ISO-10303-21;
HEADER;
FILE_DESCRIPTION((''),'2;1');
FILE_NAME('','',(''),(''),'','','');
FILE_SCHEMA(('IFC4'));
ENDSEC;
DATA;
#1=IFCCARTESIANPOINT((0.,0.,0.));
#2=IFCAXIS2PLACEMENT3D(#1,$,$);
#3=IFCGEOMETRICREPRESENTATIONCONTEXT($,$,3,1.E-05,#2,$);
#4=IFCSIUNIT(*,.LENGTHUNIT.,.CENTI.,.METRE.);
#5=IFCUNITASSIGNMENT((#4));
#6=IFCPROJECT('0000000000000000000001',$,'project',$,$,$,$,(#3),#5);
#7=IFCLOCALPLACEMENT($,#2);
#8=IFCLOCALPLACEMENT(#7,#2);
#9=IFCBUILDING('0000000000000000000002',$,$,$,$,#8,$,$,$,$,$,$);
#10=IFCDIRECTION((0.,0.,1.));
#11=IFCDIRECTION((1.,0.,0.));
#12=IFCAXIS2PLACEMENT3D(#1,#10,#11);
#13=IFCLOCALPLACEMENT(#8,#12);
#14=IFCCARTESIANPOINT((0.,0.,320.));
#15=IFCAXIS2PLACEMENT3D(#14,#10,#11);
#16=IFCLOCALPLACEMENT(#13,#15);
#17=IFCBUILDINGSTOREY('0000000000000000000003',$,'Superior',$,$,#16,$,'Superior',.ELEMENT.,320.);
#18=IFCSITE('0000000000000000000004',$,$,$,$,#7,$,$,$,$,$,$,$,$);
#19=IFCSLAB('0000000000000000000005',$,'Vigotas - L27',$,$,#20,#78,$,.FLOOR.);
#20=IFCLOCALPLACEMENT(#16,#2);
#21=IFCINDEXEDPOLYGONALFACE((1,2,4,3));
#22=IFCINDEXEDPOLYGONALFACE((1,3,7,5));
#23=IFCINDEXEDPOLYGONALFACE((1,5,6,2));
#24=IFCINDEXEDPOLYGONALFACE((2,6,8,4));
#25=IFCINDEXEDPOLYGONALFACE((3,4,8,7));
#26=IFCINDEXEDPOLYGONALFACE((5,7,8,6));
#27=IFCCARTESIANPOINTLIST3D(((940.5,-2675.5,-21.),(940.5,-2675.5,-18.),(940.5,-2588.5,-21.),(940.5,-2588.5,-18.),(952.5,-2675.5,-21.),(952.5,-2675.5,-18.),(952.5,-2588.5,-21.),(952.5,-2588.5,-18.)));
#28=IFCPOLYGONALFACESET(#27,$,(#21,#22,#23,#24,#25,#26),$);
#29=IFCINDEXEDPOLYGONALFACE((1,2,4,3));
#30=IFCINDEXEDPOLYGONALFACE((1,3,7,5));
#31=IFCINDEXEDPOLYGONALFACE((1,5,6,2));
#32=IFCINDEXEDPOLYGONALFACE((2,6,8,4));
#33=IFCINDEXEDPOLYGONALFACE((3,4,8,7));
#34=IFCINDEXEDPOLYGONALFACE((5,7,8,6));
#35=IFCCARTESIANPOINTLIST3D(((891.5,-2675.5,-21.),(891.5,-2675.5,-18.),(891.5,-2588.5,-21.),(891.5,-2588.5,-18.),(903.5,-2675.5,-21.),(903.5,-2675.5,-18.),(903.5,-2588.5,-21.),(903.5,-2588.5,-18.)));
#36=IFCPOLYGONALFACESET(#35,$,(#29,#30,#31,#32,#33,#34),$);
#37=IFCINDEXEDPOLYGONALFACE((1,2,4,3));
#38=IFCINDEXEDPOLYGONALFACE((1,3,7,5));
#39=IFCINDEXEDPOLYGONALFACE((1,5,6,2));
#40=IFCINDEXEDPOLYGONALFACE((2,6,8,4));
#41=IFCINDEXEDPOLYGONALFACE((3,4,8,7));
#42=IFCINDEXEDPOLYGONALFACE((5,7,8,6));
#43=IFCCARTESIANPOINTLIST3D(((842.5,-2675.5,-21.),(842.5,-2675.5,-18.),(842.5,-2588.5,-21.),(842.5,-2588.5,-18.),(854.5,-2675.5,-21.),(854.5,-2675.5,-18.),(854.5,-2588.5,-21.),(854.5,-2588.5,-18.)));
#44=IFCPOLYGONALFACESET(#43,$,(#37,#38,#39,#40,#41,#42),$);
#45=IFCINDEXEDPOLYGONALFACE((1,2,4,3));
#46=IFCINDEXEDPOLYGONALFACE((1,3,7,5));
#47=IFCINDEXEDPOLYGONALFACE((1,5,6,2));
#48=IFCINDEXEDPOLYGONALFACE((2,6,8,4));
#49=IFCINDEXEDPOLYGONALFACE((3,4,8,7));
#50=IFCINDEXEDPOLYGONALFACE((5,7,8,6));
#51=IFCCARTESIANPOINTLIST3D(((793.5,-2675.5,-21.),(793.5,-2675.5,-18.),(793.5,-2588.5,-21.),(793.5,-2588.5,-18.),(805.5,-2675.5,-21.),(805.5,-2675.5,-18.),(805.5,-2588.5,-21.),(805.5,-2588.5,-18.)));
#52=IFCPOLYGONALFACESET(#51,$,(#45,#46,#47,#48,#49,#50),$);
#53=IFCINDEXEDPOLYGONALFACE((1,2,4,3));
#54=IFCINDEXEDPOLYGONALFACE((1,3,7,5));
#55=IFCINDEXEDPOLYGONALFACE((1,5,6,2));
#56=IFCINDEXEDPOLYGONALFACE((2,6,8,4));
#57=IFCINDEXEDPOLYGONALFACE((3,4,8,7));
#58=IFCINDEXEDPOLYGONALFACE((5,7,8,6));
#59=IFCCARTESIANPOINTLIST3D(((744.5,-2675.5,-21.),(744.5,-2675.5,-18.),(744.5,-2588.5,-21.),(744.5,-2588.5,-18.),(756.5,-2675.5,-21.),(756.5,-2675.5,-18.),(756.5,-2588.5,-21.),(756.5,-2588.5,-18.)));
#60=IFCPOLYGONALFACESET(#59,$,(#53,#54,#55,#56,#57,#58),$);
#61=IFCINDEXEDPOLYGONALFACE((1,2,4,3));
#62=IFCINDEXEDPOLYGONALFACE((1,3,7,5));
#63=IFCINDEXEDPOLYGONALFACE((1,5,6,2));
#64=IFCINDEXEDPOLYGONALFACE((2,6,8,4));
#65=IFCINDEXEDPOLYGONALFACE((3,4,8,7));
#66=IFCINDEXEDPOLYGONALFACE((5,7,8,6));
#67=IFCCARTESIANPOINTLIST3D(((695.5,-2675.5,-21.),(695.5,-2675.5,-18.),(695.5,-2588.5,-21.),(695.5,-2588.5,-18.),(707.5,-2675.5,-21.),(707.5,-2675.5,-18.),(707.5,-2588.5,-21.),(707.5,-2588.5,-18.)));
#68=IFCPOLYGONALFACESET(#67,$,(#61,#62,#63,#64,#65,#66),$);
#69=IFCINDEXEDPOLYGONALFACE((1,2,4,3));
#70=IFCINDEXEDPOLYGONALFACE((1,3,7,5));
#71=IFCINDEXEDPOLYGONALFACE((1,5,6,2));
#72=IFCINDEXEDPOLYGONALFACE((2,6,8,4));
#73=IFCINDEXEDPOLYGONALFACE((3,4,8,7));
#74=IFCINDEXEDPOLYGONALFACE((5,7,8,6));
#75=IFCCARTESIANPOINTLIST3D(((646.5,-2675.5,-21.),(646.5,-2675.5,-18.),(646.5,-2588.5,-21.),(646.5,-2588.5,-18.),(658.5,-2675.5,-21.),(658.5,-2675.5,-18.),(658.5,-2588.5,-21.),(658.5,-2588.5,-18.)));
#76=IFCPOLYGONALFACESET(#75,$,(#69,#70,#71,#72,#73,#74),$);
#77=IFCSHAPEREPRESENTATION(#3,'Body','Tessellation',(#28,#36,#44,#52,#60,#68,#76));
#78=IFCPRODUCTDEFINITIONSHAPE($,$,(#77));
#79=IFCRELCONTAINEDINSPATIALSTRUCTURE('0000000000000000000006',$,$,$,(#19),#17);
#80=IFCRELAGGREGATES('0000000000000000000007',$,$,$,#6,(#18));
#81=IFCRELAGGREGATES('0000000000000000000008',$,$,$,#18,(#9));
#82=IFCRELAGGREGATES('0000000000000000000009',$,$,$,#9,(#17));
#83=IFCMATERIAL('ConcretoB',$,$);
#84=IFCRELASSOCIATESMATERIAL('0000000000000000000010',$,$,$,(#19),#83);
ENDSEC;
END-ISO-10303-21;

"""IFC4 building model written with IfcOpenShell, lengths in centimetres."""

from ifc_helpers import new_model, si_unit, frame, origin, origin_with_axes, place, context, project, spatial, polyline, outline, extrude, material, element, save


model = new_model("IFC4")

# Units and contexts
context_of_model = context(None, 3, precision=1e-05, world=origin())
ifc_project = project(units=[si_unit("LENGTHUNIT", "METRE", prefix="CENTI")], contexts=[context_of_model])

# Site, building, storey
site_placement = place(None, origin())
site = spatial("IfcSite", under=ifc_project, at=site_placement)
building_placement = place(site_placement, origin())
building = spatial("IfcBuilding", under=site, at=building_placement)
placement = place(building_placement, origin_with_axes())
storey_placement = place(placement, frame((0.0, 0.0, 320.0), z_axis=(0.0, 0.0, 1.0), x_axis=(1.0, 0.0, 0.0)))
storey = spatial("IfcBuildingStorey", under=building, at=storey_placement, Name="Superior", LongName="Superior", CompositionType="ELEMENT", Elevation=320.0)

# Shared definitions
ifc_material = material(Name="ConcretoB")

# Slab
slab_1_placement = place(storey_placement, frame((799.5, -2632.0, -18.0), z_axis=(0.0, 0.0, 1.0), x_axis=(1.0, 0.0, 0.0)))
element("IfcSlab", 1, at=slab_1_placement, inside=storey, material=ifc_material, Name="Vigotas - L27", PredefinedType="FLOOR", context=context_of_model, shape_type="SolidModel", body=[
    extrude(outline(polyline([(6.0, 1.5), (-6.0, 1.5), (-6.0, -1.5), (6.0, -1.5), (6.0, 1.5), (6.0, 1.5)])), frame((147.0, -43.5, -1.5), z_axis=(0.0, 1.0, 0.0), x_axis=(1.0, 0.0, 0.0)), (0.0, 0.0, 1.0), 87.0),
    extrude(outline(polyline([(6.0, 1.5), (-6.0, 1.5), (-6.0, -1.5), (6.0, -1.5), (6.0, 1.5), (6.0, 1.5)])), frame((98.0, -43.5, -1.5), z_axis=(0.0, 1.0, 0.0), x_axis=(1.0, 0.0, 0.0)), (0.0, 0.0, 1.0), 87.0),
    extrude(outline(polyline([(6.0, 1.5), (-6.0, 1.5), (-6.0, -1.5), (6.0, -1.5), (6.0, 1.5), (6.0, 1.5)])), frame((49.0, -43.5, -1.5), z_axis=(0.0, 1.0, 0.0), x_axis=(1.0, 0.0, 0.0)), (0.0, 0.0, 1.0), 87.0),
    extrude(outline(polyline([(6.0, 1.5), (-6.0, 1.5), (-6.0, -1.5), (6.0, -1.5), (6.0, 1.5), (6.0, 1.5)])), frame((0.0, -43.5, -1.5), z_axis=(0.0, 1.0, 0.0), x_axis=(1.0, 0.0, 0.0)), (0.0, 0.0, 1.0), 87.0),
    extrude(outline(polyline([(6.0, 1.5), (-6.0, 1.5), (-6.0, -1.5), (6.0, -1.5), (6.0, 1.5), (6.0, 1.5)])), frame((-49.0, -43.5, -1.5), z_axis=(0.0, 1.0, 0.0), x_axis=(1.0, 0.0, 0.0)), (0.0, 0.0, 1.0), 87.0),
    extrude(outline(polyline([(6.0, 1.5), (-6.0, 1.5), (-6.0, -1.5), (6.0, -1.5), (6.0, 1.5), (6.0, 1.5)])), frame((-98.0, -43.5, -1.5), z_axis=(0.0, 1.0, 0.0), x_axis=(1.0, 0.0, 0.0)), (0.0, 0.0, 1.0), 87.0),
    extrude(outline(polyline([(6.0, 1.5), (-6.0, 1.5), (-6.0, -1.5), (6.0, -1.5), (6.0, 1.5), (6.0, 1.5)])), frame((-147.0, -43.5, -1.5), z_axis=(0.0, 1.0, 0.0), x_axis=(1.0, 0.0, 0.0)), (0.0, 0.0, 1.0), 87.0),
])

save(model, "model.ifc")
